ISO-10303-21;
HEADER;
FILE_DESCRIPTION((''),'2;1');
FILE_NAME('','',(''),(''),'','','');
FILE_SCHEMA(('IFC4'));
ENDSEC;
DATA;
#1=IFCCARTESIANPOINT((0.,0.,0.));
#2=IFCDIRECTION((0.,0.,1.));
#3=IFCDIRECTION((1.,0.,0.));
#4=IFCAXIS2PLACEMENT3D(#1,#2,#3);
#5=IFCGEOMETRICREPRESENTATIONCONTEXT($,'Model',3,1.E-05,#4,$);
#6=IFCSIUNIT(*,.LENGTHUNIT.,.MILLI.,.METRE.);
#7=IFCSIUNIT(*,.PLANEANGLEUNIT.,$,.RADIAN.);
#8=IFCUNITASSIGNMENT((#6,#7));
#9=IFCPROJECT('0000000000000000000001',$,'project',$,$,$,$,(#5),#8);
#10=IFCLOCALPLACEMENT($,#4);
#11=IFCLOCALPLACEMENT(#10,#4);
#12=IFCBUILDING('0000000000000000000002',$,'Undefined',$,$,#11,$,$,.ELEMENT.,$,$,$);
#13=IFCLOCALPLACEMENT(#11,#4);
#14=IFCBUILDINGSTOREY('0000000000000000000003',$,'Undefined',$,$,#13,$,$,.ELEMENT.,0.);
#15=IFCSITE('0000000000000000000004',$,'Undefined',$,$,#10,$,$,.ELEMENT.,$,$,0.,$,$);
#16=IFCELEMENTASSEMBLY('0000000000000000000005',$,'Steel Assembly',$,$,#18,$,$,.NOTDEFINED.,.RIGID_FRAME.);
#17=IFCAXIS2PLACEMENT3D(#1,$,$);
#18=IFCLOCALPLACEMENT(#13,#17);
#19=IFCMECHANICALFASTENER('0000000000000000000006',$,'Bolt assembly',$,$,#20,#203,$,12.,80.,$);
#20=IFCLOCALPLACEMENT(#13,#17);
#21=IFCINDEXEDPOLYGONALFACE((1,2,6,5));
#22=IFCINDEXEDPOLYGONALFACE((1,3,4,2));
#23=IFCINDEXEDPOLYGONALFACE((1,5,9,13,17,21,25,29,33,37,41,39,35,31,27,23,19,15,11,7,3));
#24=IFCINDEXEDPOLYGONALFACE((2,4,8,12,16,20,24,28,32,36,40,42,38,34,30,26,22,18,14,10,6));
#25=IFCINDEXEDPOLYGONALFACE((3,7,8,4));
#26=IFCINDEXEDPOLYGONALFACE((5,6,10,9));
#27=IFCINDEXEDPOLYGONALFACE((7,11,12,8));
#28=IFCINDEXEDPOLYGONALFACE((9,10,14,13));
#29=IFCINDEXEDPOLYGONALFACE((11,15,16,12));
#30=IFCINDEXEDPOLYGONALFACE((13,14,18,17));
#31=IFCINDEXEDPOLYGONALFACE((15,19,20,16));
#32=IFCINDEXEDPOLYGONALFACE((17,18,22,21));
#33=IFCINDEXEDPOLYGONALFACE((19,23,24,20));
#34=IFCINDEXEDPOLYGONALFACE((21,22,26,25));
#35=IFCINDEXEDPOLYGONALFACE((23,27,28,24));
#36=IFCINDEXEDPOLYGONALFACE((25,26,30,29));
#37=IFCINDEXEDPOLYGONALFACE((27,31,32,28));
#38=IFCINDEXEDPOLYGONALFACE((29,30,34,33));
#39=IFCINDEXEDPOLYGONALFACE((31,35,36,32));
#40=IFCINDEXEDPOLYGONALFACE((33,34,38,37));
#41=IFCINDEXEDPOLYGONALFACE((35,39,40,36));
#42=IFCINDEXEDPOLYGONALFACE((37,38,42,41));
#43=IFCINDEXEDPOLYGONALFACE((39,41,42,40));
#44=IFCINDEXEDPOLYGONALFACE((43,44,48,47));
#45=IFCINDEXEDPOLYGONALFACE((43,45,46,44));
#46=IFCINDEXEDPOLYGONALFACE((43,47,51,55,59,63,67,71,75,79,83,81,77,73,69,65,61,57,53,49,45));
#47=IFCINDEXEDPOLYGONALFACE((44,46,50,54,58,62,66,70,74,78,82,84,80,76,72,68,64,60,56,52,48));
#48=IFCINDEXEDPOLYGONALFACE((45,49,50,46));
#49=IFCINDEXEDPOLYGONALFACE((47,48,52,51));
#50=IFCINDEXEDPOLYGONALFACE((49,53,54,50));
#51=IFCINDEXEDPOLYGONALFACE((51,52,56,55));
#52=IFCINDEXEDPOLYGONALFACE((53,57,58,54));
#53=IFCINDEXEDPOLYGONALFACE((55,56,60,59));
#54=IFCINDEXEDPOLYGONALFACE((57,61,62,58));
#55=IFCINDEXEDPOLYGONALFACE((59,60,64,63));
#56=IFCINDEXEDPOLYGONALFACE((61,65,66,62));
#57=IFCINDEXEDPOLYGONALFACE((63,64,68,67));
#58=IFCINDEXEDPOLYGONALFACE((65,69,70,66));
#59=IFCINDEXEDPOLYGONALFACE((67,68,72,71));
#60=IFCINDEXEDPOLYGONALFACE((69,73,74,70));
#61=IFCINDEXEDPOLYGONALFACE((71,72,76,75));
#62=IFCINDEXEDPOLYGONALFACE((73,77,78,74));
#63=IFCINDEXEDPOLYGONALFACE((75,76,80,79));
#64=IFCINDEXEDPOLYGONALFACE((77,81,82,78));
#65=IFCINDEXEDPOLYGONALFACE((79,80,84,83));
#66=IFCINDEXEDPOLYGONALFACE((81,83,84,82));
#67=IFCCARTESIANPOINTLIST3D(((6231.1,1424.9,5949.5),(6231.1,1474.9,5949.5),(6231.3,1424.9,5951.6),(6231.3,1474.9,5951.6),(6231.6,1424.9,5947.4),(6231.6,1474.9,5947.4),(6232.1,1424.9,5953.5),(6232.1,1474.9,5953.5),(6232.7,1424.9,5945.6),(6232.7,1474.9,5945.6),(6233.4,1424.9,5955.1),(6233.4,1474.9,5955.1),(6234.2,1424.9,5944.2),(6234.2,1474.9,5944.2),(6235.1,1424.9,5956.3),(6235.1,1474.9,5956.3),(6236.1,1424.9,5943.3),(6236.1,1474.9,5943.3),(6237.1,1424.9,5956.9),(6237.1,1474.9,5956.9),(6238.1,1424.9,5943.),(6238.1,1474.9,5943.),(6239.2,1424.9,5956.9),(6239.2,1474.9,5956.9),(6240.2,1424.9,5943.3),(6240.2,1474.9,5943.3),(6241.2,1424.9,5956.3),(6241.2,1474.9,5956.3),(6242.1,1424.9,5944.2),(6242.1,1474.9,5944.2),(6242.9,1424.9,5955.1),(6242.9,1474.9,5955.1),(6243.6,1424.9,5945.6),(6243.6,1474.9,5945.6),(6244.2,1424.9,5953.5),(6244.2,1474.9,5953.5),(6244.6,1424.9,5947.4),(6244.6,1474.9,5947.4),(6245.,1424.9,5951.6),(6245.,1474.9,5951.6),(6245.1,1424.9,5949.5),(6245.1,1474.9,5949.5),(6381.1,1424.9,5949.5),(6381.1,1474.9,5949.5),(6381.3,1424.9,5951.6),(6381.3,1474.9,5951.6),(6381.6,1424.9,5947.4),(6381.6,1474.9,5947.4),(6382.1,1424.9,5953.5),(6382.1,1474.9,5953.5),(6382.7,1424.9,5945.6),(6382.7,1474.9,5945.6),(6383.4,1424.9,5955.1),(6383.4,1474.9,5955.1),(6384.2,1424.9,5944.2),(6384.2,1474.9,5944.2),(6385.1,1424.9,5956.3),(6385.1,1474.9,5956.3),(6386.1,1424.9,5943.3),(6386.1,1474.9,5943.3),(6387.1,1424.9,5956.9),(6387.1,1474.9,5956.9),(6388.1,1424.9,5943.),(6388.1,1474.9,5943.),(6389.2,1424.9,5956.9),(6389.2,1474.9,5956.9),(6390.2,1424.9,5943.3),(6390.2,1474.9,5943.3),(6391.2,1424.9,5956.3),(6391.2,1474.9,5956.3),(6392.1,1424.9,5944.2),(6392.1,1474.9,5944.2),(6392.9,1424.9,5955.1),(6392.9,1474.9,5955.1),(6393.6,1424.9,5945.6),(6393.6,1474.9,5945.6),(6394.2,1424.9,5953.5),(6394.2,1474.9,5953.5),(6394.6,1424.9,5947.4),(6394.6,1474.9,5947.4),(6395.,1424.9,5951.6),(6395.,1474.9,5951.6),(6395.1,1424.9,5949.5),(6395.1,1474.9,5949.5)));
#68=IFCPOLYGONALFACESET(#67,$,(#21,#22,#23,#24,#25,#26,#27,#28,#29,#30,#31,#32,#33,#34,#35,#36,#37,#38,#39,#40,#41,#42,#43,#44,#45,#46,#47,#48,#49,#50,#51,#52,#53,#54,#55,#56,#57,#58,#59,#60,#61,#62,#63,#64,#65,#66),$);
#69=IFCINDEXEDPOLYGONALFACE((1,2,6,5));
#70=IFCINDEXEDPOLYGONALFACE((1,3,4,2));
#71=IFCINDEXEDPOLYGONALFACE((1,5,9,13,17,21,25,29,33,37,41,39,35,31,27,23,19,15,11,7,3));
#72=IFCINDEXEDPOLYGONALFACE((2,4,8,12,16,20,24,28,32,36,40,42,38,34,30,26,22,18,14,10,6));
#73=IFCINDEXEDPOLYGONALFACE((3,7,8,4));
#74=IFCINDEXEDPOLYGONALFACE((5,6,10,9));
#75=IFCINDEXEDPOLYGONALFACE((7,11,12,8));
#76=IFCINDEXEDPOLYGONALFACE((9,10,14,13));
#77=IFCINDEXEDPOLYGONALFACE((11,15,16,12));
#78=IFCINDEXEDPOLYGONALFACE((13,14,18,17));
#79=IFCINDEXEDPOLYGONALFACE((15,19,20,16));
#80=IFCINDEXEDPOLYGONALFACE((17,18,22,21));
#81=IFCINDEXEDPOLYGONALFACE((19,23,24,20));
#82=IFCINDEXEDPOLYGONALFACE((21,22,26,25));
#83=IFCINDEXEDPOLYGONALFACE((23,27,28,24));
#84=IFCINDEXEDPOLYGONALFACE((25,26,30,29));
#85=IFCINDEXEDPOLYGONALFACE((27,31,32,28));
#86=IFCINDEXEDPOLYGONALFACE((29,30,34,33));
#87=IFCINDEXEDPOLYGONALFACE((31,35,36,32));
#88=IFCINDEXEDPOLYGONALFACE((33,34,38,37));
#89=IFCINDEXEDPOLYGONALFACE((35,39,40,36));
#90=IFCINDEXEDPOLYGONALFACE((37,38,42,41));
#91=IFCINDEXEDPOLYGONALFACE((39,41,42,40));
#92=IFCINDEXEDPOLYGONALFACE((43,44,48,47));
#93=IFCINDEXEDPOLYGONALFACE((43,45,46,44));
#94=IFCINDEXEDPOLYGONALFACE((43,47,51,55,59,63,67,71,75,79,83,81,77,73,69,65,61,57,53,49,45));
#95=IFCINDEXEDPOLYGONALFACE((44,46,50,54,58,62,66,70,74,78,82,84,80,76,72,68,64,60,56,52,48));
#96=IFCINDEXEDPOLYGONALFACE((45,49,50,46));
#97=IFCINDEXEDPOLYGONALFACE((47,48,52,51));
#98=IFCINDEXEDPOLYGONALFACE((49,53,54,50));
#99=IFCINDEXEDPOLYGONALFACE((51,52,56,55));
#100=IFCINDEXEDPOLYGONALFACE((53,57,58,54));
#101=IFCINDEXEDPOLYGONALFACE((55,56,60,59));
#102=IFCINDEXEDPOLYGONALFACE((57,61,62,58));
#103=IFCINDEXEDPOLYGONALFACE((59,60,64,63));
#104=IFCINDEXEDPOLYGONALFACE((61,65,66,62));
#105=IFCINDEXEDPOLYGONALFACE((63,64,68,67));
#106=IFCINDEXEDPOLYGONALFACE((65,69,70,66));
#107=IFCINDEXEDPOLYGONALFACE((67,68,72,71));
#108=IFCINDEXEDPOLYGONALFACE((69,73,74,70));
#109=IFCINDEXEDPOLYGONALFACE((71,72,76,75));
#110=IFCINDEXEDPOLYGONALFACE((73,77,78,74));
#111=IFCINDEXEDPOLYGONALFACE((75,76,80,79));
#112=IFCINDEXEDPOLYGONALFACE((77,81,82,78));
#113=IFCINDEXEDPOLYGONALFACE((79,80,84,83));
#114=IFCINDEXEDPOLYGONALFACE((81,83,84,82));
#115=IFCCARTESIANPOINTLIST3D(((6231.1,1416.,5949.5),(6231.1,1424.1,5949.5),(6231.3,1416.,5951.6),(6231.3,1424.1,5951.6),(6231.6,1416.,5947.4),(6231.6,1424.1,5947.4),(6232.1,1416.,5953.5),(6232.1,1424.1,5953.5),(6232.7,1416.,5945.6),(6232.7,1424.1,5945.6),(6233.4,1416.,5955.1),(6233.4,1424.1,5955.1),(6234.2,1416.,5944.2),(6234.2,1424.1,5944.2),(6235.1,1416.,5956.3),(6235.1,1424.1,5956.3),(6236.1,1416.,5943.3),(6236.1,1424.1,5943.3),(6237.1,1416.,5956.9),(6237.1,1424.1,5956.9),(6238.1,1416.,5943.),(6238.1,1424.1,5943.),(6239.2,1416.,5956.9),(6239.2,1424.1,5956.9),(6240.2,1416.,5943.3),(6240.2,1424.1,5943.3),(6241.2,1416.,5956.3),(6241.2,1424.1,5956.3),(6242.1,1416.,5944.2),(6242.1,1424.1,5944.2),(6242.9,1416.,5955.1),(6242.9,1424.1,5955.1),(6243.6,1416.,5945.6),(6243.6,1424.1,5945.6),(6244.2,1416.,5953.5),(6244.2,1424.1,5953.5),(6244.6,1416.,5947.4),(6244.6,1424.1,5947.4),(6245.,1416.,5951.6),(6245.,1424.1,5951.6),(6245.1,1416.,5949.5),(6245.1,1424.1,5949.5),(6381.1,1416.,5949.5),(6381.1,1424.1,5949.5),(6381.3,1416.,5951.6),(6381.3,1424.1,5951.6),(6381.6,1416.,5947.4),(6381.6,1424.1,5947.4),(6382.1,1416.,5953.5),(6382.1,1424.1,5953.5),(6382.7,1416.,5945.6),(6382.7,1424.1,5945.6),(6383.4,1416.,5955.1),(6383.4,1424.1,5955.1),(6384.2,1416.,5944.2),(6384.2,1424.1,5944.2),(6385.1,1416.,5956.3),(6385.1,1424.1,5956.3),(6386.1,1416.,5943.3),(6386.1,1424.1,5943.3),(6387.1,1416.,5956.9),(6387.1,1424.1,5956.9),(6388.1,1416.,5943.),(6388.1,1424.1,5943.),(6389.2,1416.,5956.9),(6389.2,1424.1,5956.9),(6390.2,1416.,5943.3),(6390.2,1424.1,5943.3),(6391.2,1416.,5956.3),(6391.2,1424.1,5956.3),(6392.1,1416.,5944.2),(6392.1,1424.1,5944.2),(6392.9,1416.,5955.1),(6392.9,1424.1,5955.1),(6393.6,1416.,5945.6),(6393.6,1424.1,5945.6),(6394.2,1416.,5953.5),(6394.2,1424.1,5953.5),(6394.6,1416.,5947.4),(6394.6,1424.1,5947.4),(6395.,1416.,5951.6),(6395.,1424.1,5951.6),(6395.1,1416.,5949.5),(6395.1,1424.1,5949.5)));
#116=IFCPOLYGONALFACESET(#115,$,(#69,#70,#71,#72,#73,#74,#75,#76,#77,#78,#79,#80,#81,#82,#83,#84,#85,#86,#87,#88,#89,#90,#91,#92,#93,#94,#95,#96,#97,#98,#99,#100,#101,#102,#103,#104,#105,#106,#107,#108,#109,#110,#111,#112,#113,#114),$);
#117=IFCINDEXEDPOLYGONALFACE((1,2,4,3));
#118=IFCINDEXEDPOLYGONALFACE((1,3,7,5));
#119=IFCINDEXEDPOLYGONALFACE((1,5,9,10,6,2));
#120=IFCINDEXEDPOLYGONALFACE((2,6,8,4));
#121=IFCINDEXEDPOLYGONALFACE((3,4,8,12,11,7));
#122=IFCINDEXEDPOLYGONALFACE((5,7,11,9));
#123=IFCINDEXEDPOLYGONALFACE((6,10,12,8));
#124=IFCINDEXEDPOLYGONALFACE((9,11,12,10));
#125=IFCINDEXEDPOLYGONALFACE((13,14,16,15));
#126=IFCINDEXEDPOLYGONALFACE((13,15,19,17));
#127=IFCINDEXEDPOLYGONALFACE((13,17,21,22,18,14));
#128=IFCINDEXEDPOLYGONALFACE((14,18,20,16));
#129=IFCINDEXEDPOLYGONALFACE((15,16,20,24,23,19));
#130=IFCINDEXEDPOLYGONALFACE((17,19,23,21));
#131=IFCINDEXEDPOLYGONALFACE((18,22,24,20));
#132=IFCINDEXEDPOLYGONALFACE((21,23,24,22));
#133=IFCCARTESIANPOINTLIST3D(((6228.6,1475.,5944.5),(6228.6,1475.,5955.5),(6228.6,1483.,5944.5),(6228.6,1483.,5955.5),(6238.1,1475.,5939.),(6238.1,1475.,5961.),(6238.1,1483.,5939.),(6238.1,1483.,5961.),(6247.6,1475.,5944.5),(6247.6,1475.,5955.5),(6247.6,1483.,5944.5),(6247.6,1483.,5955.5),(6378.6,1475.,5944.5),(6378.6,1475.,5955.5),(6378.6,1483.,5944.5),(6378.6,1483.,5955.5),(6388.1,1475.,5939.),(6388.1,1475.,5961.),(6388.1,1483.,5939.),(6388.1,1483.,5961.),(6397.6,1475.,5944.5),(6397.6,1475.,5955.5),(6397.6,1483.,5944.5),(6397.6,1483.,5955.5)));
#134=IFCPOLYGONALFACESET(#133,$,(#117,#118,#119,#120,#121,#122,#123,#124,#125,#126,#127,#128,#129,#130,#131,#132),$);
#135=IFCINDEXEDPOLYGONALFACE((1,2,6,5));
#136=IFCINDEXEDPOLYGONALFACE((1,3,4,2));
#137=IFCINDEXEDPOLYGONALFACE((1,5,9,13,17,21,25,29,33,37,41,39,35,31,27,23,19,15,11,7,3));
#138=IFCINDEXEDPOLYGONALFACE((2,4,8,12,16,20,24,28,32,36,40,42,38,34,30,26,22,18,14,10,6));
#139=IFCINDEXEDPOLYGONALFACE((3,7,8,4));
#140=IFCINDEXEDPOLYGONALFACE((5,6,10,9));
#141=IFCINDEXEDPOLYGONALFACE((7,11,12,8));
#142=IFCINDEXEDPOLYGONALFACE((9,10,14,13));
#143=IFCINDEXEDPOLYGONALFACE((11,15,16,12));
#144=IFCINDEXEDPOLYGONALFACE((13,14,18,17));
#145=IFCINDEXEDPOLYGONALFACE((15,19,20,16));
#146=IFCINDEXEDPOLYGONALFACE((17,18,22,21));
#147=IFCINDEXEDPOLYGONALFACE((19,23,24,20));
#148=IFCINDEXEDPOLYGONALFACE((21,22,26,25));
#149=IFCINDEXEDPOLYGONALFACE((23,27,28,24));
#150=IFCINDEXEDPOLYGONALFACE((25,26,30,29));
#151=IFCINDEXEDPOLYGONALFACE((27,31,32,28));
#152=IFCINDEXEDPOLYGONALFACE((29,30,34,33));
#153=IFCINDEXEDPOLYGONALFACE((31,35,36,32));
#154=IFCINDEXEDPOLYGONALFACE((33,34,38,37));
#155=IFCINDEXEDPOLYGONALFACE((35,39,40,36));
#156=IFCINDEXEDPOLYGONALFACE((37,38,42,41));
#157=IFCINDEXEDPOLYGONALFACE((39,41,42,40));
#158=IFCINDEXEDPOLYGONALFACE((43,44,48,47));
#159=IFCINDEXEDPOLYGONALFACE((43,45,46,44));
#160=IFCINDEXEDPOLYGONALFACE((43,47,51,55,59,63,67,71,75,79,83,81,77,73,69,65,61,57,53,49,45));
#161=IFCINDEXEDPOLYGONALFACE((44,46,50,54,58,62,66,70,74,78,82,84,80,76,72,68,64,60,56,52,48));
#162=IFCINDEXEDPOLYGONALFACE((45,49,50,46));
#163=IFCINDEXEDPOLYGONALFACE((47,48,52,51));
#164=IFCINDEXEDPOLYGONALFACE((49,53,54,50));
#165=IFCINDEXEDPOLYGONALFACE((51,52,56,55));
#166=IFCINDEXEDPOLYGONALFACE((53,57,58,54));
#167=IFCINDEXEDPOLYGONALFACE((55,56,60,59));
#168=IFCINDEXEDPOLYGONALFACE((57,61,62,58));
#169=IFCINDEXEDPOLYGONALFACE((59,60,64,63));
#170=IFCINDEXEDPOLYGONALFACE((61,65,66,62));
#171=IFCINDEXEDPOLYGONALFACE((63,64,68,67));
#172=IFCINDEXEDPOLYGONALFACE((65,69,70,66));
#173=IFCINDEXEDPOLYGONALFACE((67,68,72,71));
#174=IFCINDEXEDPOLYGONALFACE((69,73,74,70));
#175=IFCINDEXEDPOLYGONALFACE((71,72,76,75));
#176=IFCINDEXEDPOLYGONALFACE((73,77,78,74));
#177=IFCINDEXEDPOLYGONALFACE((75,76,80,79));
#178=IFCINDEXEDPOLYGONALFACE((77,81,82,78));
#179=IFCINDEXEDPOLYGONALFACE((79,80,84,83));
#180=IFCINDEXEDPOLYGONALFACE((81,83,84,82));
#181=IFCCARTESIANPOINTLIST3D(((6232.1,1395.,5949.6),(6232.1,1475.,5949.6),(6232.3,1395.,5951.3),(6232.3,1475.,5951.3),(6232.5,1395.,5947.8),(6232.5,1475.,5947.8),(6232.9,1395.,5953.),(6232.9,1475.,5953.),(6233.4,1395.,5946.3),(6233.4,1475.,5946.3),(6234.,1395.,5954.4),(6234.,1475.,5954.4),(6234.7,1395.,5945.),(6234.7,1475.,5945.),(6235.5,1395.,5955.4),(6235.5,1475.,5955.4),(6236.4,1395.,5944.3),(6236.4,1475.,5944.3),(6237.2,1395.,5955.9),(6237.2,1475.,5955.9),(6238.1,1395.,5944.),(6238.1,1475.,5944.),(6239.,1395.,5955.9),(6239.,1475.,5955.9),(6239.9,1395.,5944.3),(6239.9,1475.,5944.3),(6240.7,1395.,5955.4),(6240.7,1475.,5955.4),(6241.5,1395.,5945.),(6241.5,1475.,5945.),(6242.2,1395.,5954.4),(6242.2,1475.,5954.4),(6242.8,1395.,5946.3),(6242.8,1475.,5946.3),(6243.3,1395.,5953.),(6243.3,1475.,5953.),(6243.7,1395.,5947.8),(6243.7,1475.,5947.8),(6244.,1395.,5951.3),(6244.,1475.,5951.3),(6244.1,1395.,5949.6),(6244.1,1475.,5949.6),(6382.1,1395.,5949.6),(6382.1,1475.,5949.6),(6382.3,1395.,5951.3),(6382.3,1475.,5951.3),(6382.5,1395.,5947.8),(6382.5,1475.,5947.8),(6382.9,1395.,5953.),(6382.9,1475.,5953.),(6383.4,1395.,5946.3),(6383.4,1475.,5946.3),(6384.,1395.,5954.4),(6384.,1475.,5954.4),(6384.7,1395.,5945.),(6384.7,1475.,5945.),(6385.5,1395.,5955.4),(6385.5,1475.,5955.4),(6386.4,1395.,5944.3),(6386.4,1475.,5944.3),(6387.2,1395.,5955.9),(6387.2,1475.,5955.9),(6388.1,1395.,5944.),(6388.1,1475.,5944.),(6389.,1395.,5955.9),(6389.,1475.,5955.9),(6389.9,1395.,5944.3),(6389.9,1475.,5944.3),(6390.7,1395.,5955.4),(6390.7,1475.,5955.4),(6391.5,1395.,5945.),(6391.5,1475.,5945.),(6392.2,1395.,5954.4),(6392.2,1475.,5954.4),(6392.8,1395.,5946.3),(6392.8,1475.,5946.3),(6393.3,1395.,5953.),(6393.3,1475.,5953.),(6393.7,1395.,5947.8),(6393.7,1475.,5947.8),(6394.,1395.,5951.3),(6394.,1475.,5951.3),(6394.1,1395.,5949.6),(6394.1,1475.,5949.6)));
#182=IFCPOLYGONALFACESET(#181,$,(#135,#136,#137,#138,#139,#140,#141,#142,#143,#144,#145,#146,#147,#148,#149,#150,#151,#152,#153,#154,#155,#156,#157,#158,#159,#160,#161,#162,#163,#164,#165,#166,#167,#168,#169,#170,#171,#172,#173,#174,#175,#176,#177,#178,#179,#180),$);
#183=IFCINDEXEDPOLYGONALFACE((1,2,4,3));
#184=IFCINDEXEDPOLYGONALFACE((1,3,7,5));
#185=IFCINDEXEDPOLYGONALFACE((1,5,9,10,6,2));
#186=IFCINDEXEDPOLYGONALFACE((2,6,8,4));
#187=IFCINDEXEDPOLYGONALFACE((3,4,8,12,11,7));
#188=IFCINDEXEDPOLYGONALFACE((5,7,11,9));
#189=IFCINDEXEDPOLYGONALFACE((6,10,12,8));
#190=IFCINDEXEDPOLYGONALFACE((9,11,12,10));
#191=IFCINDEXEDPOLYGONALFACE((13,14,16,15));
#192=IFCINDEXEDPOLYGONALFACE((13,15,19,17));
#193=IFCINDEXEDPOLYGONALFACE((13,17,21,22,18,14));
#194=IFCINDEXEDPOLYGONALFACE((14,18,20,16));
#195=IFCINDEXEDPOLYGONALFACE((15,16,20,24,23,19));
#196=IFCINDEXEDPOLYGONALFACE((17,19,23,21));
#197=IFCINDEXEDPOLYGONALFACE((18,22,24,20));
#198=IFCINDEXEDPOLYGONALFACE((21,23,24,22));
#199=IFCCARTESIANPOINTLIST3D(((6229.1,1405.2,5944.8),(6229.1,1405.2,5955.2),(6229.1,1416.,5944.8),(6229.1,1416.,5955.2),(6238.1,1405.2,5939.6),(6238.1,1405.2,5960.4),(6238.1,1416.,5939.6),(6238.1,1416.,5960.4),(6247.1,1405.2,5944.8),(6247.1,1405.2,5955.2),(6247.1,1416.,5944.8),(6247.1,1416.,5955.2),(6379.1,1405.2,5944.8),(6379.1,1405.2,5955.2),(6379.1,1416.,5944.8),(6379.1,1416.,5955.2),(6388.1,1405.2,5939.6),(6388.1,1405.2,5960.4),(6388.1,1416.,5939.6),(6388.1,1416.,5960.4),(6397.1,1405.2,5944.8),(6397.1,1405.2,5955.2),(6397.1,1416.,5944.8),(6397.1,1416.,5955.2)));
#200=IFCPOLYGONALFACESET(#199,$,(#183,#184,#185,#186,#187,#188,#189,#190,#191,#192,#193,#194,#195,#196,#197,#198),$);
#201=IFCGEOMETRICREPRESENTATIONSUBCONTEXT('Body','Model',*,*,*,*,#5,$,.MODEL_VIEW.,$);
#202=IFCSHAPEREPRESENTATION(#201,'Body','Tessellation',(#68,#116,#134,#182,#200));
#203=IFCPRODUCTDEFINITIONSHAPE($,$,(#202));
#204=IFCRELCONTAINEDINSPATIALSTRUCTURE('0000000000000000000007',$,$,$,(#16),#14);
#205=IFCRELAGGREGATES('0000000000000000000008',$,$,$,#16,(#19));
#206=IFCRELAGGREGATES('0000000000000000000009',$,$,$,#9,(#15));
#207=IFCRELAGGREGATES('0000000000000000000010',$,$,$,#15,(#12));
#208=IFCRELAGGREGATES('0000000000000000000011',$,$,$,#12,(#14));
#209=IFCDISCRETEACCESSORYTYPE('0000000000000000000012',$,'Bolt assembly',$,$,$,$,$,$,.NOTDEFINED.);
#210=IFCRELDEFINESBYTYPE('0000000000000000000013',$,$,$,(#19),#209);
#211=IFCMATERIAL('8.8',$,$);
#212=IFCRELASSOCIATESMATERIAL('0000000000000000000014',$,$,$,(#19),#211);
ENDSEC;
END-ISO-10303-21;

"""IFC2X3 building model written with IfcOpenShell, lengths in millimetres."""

from ifc_helpers import new_model, si_unit, frame, origin_with_axes, origin_2d_with_axis, place, context, subcontext, project, spatial, polyline, circle, outline, extrude, source, transform, mapped, material, type_object, element, aggregate, save


model = new_model("IFC2X3")

# Units and contexts
model_context = context("Model", 3, precision=1e-05, world=origin_with_axes())
body_context = subcontext(model_context, "Body", "Model", "MODEL_VIEW")
ifc_project = project(units=[si_unit("LENGTHUNIT", "METRE", prefix="MILLI"), si_unit("PLANEANGLEUNIT", "RADIAN")], contexts=[model_context])

# Site, building, storey
site_placement = place(None, origin_with_axes())
site = spatial("IfcSite", under=ifc_project, at=site_placement, Name="Undefined", CompositionType="ELEMENT", RefElevation=0.0)
building_placement = place(site_placement, origin_with_axes())
building = spatial("IfcBuilding", under=site, at=building_placement, Name="Undefined", CompositionType="ELEMENT")
storey_placement = place(building_placement, origin_with_axes())
storey = spatial("IfcBuildingStorey", under=building, at=storey_placement, Name="Undefined", CompositionType="ELEMENT", Elevation=0.0)

# Element assembly
assembly_1_placement = place(storey_placement, origin_with_axes())
assembly_1 = element("IfcElementAssembly", 1, at=assembly_1_placement, inside=storey, Name="Steel Assembly", AssemblyPlace="NOTDEFINED", PredefinedType="RIGID_FRAME")

# Mechanical fastener
ifc_material_1 = material(Name="8.8")
discrete_accessory_type_1 = type_object("IfcDiscreteAccessoryType", Name="Bolt assembly")
shared_shape_1 = source(origin_with_axes(), body_context, "Body", "SweptSolid", [
    extrude(circle(Radius=7.0, at=origin_2d_with_axis()), frame((0.0, -52.9, 0.0), z_axis=(0.0, 1.0, 0.0), x_axis=(1.0, 0.0, 0.0)), (0.0, 0.0, 1.0), 50.0),
    extrude(circle(Radius=7.0, at=origin_2d_with_axis()), frame((0.0, -2.1, 0.0), z_axis=(0.0, 1.0, 0.0), x_axis=(1.0, 0.0, 0.0)), (0.0, 0.0, 1.0), 8.1),
    extrude(outline(polyline([(11.0, 0.0), (5.5, 9.5), (-5.5, 9.5), (-11.0, 0.0), (-5.5, -9.5), (5.5, -9.5), (11.0, 0.0)])), frame((0.0, -61.0, 0.0), z_axis=(0.0, 1.0, 0.0), x_axis=(1.0, 0.0, 0.0)), (0.0, 0.0, 1.0), 8.0),
    extrude(circle(Radius=6.0, at=origin_2d_with_axis()), frame((0.0, -53.0, 0.0), z_axis=(0.0, 1.0, 0.0), x_axis=(1.0, 0.0, 0.0)), (0.0, 0.0, 1.0), 80.0),
    extrude(outline(polyline([(10.4, 0.0), (5.2, 9.0), (-5.2, 9.0), (-10.4, 0.0), (-5.2, -9.0), (5.2, -9.0), (10.4, 0.0)])), frame((0.0, 6.0, 0.0), z_axis=(0.0, 1.0, 0.0), x_axis=(1.0, 0.0, 0.0)), (0.0, 0.0, 1.0), 10.8),
])
mechanical_fastener_1_placement = place(assembly_1_placement, frame((6313.1, 1422.0, 6000.0), z_axis=(-1.0, 0.0, 0.0), x_axis=(0.0, 0.0, -1.0)))
mechanical_fastener_1 = element("IfcMechanicalFastener", 2, at=mechanical_fastener_1_placement, type_object=discrete_accessory_type_1, material=ifc_material_1, Name="Bolt assembly", NominalDiameter=12.0, NominalLength=80.0, context=body_context, shape_type="MappedRepresentation", body=[
    mapped(shared_shape_1, transform((50.0, 0.0, -75.0))),
    mapped(shared_shape_1, transform((50.0, 0.0, 75.0))),
])
aggregate(assembly_1, [mechanical_fastener_1])

save(model, "model.ifc")
